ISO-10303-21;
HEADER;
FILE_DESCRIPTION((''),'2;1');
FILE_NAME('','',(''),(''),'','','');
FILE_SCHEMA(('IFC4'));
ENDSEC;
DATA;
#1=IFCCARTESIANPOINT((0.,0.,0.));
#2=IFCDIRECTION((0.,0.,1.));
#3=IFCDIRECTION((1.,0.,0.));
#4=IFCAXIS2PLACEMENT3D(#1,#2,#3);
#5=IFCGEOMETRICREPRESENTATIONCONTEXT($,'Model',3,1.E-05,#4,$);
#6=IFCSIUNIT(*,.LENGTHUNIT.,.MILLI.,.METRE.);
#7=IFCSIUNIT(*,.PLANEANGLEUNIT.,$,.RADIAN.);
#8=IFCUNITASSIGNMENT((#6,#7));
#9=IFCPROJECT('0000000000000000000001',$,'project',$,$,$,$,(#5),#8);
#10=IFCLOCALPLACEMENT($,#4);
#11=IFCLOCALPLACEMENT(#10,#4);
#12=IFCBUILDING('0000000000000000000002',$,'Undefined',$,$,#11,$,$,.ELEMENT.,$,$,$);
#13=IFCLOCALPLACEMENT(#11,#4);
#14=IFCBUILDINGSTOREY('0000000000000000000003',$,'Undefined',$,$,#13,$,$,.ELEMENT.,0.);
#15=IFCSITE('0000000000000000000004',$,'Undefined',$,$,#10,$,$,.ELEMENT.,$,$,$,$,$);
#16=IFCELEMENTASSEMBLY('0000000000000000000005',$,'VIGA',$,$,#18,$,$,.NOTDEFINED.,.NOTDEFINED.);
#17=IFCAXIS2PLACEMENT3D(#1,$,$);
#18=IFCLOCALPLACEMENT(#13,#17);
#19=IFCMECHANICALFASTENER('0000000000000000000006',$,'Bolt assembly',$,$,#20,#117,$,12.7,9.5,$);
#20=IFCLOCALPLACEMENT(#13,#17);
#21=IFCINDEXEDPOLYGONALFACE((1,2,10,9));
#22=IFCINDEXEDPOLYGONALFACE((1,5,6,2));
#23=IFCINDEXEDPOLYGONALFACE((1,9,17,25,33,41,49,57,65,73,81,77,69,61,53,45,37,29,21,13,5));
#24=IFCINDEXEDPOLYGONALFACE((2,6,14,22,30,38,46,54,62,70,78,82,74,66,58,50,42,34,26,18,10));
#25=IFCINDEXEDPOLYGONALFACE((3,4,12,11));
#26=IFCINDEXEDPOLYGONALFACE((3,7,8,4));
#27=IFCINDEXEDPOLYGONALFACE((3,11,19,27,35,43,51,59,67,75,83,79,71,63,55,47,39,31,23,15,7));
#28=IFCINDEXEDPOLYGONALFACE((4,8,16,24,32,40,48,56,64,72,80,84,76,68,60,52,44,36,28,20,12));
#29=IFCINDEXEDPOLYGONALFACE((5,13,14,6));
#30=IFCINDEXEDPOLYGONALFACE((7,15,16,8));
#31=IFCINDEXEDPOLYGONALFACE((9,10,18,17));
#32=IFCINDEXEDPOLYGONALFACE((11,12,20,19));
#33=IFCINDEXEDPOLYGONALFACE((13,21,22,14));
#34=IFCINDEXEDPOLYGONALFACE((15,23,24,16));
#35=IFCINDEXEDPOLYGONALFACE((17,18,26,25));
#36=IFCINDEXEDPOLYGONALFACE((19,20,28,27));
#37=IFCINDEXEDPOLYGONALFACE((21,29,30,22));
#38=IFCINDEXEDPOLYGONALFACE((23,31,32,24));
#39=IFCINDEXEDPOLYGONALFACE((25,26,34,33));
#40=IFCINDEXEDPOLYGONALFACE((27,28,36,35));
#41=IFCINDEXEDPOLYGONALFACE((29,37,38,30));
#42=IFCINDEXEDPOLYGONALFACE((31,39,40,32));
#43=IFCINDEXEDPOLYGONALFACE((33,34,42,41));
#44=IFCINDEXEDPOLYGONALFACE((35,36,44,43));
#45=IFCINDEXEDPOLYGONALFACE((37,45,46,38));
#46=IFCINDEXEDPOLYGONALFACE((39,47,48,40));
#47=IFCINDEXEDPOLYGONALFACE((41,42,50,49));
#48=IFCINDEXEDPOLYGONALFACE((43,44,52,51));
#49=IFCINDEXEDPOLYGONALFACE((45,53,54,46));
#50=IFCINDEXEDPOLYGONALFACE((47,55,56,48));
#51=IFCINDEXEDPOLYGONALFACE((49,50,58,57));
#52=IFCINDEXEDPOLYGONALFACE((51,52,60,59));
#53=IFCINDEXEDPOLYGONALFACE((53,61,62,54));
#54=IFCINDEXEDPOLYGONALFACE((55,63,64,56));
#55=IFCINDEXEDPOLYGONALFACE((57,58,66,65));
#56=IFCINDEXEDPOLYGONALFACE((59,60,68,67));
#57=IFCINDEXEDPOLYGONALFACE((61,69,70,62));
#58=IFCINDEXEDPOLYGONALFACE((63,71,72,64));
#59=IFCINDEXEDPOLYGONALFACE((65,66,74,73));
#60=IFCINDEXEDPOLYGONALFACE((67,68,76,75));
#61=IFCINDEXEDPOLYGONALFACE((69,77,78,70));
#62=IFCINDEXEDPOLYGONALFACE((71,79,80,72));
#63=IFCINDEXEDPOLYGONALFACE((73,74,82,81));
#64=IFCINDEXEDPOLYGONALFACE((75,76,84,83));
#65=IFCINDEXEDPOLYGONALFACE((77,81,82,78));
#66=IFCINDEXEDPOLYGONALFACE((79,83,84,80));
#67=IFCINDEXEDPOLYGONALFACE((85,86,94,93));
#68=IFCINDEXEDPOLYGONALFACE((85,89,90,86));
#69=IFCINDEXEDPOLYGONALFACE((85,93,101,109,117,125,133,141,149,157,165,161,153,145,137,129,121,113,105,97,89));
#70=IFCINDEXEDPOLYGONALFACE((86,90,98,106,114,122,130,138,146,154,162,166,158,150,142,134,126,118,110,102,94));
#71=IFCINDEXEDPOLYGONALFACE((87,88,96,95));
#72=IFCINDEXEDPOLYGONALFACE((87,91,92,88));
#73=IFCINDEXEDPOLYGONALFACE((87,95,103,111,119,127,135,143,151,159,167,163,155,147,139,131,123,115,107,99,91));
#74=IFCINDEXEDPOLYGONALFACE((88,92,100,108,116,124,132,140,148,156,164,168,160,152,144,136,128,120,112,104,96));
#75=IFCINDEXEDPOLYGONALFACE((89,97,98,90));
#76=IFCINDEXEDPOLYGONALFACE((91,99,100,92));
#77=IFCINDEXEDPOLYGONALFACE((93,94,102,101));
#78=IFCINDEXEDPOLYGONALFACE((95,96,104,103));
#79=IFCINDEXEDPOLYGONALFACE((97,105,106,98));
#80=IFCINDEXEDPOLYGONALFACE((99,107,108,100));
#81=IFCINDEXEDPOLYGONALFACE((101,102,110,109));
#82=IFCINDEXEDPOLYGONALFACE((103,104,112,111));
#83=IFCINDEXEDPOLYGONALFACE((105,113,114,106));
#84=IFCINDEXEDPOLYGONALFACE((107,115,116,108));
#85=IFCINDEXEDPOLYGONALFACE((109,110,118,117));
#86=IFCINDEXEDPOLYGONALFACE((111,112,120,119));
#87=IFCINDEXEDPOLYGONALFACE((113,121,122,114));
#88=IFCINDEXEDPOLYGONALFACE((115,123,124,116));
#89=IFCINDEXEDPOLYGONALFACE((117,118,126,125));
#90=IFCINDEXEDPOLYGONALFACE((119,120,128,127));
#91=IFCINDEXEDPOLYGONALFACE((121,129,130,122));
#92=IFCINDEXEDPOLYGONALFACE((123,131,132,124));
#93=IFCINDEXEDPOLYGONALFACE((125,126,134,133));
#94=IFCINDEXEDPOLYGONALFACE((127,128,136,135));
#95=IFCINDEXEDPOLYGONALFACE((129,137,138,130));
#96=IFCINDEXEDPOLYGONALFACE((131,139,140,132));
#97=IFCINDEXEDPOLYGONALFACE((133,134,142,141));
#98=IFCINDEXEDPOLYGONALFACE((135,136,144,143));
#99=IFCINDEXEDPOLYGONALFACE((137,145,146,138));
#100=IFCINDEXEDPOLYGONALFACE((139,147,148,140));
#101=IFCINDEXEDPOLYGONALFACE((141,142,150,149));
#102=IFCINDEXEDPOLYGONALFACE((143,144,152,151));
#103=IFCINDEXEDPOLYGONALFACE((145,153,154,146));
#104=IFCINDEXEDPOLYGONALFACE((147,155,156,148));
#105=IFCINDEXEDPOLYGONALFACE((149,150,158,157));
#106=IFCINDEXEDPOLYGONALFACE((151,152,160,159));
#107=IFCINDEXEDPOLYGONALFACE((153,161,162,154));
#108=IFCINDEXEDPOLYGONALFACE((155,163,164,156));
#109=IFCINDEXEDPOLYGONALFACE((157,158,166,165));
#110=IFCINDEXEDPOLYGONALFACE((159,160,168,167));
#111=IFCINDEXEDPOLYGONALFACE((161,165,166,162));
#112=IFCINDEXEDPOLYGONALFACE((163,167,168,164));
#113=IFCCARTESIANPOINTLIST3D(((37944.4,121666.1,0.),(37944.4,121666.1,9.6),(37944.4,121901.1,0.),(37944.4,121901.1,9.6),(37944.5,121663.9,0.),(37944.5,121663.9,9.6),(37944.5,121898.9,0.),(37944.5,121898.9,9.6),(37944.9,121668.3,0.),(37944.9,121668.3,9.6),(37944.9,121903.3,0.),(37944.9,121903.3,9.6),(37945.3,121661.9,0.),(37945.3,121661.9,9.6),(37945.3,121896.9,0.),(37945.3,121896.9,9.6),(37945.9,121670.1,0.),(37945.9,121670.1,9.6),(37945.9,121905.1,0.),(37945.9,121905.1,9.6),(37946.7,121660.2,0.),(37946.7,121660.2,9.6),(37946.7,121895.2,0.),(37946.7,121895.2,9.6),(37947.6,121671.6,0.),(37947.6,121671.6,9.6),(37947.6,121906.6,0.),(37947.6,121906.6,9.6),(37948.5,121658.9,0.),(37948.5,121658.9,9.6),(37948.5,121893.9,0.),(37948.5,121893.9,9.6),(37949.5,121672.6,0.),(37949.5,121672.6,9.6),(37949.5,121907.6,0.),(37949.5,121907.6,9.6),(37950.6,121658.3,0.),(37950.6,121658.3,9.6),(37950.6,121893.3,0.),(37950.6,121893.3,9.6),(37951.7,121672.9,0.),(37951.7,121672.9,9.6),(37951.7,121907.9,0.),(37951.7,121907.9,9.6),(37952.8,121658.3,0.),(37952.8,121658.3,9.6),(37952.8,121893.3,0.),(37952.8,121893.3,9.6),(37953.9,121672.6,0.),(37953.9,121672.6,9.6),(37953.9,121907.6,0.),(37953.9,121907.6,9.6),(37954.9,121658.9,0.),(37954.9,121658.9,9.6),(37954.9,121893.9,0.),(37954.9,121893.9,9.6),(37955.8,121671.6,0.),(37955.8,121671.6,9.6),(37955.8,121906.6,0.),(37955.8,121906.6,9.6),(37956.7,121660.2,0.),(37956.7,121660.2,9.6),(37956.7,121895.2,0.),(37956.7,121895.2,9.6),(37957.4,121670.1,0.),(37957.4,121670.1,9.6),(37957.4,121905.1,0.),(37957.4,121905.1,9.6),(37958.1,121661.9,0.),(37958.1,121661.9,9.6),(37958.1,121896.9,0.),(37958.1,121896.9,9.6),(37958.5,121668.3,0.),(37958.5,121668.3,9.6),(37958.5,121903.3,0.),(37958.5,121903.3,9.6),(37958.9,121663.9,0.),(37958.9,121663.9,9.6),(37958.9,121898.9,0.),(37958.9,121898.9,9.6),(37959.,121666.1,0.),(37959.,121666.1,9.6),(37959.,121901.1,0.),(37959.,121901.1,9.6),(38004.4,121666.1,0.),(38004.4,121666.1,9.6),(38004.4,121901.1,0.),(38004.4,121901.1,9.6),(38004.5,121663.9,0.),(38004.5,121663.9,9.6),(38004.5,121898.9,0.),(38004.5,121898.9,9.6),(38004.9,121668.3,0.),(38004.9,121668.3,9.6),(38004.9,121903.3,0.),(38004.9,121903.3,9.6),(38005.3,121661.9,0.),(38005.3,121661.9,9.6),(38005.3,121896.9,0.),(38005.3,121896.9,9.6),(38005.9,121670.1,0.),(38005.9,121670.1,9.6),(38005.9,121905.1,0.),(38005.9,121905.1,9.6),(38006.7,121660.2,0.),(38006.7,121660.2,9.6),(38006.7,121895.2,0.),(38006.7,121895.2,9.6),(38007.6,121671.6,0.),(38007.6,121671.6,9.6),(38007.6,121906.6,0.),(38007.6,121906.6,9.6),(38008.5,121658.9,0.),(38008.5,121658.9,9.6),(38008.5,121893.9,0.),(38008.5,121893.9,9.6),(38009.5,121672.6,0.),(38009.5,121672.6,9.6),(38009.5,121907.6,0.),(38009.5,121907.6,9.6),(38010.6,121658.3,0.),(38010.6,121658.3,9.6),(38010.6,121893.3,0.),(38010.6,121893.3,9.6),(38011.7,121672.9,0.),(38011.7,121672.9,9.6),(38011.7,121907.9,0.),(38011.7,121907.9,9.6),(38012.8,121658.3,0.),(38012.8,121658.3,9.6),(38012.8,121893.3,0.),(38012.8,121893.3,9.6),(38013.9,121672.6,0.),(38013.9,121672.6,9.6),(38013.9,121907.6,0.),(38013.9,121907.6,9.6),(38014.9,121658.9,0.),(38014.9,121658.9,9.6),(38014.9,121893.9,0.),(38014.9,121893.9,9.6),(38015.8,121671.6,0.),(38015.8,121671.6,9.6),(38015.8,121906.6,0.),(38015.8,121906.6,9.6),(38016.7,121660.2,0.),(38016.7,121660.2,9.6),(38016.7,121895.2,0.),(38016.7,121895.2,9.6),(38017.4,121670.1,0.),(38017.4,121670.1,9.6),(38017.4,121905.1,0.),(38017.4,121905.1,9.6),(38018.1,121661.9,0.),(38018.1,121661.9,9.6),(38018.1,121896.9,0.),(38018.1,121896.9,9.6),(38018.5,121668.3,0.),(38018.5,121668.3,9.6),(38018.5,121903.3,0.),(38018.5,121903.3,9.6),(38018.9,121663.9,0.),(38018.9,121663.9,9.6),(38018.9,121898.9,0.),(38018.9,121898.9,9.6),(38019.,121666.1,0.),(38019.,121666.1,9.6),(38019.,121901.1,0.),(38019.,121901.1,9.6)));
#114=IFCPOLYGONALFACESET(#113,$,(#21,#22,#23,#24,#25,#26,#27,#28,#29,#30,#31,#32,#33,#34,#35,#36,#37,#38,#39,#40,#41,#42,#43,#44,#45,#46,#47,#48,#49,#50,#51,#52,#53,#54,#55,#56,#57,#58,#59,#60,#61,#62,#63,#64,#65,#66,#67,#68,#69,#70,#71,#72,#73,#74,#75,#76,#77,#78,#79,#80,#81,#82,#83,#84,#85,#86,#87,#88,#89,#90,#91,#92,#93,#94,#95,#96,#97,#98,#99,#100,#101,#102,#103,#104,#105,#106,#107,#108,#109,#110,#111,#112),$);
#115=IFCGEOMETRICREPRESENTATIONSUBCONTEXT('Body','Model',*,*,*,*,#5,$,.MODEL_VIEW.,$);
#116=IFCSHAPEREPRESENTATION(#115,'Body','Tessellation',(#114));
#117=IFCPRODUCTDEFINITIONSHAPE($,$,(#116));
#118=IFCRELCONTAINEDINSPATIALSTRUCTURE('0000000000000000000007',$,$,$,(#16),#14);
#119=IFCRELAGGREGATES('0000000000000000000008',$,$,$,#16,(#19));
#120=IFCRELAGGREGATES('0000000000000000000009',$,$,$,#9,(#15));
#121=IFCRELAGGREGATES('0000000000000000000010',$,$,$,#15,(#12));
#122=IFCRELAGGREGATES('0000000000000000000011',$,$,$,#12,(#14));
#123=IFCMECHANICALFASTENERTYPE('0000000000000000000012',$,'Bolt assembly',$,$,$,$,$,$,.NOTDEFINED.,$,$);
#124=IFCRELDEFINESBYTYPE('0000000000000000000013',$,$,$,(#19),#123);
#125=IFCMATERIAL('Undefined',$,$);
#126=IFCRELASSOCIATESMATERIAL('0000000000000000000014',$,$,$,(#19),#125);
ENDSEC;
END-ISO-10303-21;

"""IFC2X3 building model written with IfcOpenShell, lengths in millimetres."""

from ifc_helpers import new_model, si_unit, frame, origin_with_axes, origin_2d_with_axis, place, context, subcontext, project, spatial, circle, extrude, source, transform, mapped, material, type_object, element, aggregate, save


model = new_model("IFC2X3")

# Units and contexts
model_context = context("Model", 3, precision=1e-05, world=origin_with_axes())
body_context = subcontext(model_context, "Body", "Model", "MODEL_VIEW")
ifc_project = project(units=[si_unit("LENGTHUNIT", "METRE", prefix="MILLI"), si_unit("PLANEANGLEUNIT", "RADIAN")], contexts=[model_context])

# Site, building, storey
site_placement = place(None, origin_with_axes())
site = spatial("IfcSite", under=ifc_project, at=site_placement, Name="Undefined", CompositionType="ELEMENT")
building_placement = place(site_placement, origin_with_axes())
building = spatial("IfcBuilding", under=site, at=building_placement, Name="Undefined", CompositionType="ELEMENT")
storey_placement = place(building_placement, origin_with_axes())
storey = spatial("IfcBuildingStorey", under=building, at=storey_placement, Name="Undefined", CompositionType="ELEMENT", Elevation=0.0)

# Element assembly
assembly_1_placement = place(storey_placement, origin_with_axes())
assembly_1 = element("IfcElementAssembly", 1, at=assembly_1_placement, inside=storey, Name="VIGA", AssemblyPlace="NOTDEFINED", PredefinedType="NOTDEFINED")

# Mechanical fastener
ifc_material_1 = material(Name="Undefined")
mechanical_fastener_type = type_object("IfcMechanicalFastenerType", Name="Bolt assembly")
shared_shape_1 = source(origin_with_axes(), body_context, "Body", "SweptSolid", [
    extrude(circle(Radius=7.3, at=origin_2d_with_axis()), frame((0.0, -9.5, 0.0), z_axis=(0.0, 1.0, 0.0), x_axis=(1.0, 0.0, 0.0)), (0.0, 0.0, 1.0), 9.6),
])
mechanical_fastener_1_placement = place(assembly_1_placement, frame((37981.7, 121665.6, 9.5), z_axis=(1.0, 0.0, 0.0), x_axis=(0.0, 1.0, 0.0)))
mechanical_fastener_1 = element("IfcMechanicalFastener", 2, at=mechanical_fastener_1_placement, type_object=mechanical_fastener_type, material=ifc_material_1, Name="Bolt assembly", NominalDiameter=12.7, NominalLength=9.5, context=body_context, shape_type="MappedRepresentation", body=[
    mapped(shared_shape_1, transform((0.0, 0.0, -30.0))),
    mapped(shared_shape_1, transform((235.0, 0.0, -30.0))),
    mapped(shared_shape_1, transform((0.0, 0.0, 30.0))),
    mapped(shared_shape_1, transform((235.0, 0.0, 30.0))),
])
aggregate(assembly_1, [mechanical_fastener_1])

save(model, "model.ifc")
